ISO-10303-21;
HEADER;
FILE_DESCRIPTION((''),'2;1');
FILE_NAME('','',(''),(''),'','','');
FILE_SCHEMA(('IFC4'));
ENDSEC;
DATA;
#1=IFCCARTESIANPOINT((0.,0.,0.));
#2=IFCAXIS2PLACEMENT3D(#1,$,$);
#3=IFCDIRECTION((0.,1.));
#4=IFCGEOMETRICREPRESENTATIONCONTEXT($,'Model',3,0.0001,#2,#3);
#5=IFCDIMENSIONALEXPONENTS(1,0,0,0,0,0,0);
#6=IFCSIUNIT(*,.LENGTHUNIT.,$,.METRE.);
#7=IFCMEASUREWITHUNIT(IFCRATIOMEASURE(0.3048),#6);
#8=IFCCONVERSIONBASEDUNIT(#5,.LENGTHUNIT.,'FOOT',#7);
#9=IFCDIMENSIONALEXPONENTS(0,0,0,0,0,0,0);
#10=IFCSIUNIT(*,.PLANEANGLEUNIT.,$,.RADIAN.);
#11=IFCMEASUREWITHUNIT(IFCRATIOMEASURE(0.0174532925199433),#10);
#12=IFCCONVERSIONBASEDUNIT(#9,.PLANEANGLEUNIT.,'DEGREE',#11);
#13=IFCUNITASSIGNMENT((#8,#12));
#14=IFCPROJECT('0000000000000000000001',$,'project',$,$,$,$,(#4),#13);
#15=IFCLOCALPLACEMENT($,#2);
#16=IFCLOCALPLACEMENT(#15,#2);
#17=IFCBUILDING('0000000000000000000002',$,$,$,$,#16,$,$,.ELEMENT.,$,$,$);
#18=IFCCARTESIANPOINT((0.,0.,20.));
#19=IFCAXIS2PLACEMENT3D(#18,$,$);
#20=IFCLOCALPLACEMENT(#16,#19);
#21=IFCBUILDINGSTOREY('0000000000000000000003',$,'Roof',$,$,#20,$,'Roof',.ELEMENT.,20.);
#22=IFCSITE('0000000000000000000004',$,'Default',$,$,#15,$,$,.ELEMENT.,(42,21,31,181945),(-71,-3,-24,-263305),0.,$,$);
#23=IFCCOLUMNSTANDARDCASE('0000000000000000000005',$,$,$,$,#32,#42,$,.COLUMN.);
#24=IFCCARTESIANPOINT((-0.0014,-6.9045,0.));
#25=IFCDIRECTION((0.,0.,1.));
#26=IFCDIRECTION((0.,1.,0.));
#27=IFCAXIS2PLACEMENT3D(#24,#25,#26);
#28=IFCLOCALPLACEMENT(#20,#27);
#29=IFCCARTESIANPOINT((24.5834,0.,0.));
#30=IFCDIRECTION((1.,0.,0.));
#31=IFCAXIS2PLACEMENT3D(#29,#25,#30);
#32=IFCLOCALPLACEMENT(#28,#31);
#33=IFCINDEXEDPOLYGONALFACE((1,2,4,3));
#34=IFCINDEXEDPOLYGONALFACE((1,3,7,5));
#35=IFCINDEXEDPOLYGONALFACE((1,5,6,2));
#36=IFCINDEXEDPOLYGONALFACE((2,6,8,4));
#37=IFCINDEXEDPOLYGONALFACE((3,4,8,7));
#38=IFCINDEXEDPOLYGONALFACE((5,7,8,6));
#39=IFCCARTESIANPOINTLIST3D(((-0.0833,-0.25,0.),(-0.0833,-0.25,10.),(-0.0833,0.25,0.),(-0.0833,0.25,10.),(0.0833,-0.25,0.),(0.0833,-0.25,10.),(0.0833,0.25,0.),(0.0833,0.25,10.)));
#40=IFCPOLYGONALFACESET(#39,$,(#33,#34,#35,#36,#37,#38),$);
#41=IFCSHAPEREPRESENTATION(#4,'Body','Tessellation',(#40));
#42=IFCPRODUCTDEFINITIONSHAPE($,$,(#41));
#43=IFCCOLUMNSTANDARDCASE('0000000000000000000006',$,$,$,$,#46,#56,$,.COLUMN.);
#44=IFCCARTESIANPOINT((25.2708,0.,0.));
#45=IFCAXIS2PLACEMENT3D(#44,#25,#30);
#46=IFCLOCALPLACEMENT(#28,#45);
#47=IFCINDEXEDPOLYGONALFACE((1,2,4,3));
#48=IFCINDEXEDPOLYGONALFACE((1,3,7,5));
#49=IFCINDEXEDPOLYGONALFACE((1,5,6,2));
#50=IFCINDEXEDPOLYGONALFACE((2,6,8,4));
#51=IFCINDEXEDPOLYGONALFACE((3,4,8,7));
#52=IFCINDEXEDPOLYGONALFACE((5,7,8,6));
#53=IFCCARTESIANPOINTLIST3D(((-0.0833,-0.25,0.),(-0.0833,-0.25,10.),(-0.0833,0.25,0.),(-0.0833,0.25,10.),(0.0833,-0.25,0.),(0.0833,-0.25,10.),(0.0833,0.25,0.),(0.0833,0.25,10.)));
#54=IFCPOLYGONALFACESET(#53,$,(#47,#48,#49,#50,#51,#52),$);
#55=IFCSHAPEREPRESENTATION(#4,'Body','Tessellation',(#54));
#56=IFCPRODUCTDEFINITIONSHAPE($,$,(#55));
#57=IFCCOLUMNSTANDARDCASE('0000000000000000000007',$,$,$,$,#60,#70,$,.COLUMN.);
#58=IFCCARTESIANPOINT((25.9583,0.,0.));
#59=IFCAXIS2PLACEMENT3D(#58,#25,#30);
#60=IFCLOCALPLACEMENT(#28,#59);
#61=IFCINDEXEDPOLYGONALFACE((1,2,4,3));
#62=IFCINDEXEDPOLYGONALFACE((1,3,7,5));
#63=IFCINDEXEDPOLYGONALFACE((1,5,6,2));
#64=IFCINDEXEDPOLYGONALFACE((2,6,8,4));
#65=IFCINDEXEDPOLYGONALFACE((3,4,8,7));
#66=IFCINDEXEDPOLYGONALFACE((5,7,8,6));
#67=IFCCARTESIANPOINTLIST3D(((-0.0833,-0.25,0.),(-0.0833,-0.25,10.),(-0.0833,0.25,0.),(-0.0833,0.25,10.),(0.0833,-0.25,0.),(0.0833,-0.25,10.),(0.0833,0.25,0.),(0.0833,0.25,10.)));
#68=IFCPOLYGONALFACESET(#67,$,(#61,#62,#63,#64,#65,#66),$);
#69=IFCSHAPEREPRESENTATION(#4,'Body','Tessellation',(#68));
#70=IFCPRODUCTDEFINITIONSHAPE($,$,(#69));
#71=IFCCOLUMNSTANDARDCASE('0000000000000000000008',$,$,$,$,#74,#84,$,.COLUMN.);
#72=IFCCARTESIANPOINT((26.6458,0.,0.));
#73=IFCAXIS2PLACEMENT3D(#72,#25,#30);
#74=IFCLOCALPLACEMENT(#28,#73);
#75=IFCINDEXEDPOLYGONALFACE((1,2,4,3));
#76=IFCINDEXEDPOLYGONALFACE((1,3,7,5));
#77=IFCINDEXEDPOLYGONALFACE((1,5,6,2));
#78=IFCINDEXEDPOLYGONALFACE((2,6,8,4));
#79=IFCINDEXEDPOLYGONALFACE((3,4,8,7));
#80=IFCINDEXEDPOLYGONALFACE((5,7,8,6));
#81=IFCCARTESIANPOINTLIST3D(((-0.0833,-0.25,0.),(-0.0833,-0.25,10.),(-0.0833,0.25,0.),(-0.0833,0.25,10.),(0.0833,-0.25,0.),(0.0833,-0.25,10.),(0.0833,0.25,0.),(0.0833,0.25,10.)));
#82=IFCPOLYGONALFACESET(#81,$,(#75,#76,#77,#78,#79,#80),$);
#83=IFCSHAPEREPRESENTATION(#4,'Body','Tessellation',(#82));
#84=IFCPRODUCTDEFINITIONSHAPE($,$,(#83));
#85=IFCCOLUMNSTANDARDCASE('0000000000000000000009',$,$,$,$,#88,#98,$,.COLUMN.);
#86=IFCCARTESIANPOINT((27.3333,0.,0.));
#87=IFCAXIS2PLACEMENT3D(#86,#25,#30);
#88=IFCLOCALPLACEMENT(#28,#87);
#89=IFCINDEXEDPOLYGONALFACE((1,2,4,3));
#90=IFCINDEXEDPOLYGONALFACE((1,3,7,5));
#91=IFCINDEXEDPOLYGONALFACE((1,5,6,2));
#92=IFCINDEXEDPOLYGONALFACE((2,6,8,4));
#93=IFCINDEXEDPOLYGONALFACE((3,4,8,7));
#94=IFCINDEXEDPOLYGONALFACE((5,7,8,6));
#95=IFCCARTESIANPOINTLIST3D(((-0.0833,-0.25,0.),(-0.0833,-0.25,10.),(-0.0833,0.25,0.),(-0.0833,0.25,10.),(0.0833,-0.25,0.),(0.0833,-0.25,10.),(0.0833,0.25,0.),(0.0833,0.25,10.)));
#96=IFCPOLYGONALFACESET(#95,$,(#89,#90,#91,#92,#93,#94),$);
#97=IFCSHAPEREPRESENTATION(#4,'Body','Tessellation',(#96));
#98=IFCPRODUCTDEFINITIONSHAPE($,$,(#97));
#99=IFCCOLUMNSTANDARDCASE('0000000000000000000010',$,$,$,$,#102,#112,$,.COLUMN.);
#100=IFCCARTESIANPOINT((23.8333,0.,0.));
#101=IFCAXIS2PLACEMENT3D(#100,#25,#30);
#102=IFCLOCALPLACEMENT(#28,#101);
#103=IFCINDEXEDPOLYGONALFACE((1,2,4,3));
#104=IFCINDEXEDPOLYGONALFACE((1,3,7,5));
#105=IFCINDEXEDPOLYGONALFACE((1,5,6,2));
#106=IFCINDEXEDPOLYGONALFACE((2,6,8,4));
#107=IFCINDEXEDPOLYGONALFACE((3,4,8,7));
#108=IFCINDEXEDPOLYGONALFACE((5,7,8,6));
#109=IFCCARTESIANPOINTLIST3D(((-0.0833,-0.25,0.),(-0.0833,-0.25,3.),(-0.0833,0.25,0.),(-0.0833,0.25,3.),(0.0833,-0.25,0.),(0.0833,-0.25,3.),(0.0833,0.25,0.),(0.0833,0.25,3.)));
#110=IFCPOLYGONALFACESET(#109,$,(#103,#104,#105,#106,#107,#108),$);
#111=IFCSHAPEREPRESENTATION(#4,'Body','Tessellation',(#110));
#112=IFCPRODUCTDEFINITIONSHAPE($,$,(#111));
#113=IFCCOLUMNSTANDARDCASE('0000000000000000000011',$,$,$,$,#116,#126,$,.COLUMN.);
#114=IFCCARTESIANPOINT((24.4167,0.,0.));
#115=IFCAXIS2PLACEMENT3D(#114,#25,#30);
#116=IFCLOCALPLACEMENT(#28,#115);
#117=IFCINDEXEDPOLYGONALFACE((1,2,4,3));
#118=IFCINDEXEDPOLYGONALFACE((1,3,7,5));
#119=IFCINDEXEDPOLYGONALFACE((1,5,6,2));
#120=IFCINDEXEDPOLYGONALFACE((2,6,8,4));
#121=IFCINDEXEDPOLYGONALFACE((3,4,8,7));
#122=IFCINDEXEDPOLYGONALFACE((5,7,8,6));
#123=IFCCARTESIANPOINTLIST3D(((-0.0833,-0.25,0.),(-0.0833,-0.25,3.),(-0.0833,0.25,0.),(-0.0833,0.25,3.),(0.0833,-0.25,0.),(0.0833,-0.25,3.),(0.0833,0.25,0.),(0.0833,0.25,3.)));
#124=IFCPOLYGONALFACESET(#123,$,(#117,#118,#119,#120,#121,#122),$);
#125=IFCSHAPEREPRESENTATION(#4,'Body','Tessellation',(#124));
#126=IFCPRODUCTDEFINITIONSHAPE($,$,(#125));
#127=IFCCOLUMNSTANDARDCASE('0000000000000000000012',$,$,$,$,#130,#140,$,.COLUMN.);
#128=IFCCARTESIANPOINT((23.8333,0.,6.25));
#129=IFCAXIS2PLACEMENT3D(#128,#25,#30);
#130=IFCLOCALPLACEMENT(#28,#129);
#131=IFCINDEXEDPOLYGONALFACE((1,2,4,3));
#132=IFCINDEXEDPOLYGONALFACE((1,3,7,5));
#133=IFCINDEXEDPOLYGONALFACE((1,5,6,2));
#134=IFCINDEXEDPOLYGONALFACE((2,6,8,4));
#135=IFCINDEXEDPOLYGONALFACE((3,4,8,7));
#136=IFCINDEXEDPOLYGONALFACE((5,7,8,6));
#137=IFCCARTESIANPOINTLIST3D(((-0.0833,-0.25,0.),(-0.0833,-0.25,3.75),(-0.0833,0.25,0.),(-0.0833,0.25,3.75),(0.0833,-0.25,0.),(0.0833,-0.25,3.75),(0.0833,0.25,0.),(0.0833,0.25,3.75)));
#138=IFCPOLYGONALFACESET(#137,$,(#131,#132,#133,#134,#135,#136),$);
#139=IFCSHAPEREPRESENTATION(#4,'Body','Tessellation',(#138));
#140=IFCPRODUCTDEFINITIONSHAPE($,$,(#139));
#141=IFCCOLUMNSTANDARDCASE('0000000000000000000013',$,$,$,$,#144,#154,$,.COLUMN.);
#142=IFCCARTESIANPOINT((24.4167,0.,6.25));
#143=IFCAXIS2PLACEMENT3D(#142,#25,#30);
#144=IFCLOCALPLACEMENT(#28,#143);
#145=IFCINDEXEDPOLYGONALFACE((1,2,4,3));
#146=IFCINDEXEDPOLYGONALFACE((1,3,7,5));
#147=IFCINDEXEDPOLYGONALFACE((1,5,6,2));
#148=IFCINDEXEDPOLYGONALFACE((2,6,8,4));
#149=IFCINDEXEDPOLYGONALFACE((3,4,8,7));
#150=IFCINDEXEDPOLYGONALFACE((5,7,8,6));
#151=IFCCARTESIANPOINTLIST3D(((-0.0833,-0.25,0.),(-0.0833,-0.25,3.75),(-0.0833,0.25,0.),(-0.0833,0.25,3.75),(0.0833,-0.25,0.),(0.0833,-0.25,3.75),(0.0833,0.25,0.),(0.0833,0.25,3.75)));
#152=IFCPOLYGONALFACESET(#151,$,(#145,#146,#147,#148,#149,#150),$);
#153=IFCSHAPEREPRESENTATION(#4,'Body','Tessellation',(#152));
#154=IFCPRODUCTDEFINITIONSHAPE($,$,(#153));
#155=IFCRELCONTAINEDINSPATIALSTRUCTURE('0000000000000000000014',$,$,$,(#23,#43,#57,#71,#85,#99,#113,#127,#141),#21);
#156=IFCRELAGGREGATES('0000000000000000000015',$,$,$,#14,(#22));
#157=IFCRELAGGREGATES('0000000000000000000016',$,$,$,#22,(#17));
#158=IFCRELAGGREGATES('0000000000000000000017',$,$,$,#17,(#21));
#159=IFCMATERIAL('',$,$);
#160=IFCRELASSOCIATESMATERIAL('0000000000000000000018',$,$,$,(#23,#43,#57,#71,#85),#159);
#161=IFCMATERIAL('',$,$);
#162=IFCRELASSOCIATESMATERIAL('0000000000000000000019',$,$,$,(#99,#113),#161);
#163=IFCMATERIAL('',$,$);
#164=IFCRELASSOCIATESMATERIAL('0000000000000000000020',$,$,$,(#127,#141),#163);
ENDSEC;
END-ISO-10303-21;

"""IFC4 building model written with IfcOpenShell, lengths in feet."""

from ifc_helpers import new_model, entity, si_unit, converted_unit, direction, frame, origin, place, context, project, spatial, rectangle, extrude, material, element, save


model = new_model("IFC4")

# Units and contexts
model_context = context("Model", 3, precision=0.0001, world=origin(), true_north=direction((0.0, 1.0)))
ifc_project = project(units=[converted_unit("LENGTHUNIT", "FOOT", entity("IfcRatioMeasure", 0.3048), si_unit("LENGTHUNIT", "METRE"), dimensions=[1, 0, 0, 0, 0, 0, 0]), converted_unit("PLANEANGLEUNIT", "DEGREE", entity("IfcRatioMeasure", 0.0174532925199433), si_unit("PLANEANGLEUNIT", "RADIAN"), dimensions=[0, 0, 0, 0, 0, 0, 0])], contexts=[model_context])

# Site, building, storey
site_placement = place(None, origin())
site = spatial("IfcSite", under=ifc_project, at=site_placement, Name="Default", CompositionType="ELEMENT", RefLatitude=(42, 21, 31, 181945), RefLongitude=(-71, -3, -24, -263305), RefElevation=0.0)
building_placement = place(site_placement, origin())
building = spatial("IfcBuilding", under=site, at=building_placement, CompositionType="ELEMENT")
storey_placement = place(building_placement, frame((0.0, 0.0, 20.0)))
storey = spatial("IfcBuildingStorey", under=building, at=storey_placement, Name="Roof", LongName="Roof", CompositionType="ELEMENT", Elevation=20.0)

# Columns
ifc_material_1 = material(Name="")
placement = place(storey_placement, frame((-0.0014, -6.9045, 0.0), z_axis=(0.0, 0.0, 1.0), x_axis=(0.0, 1.0, 0.0)))
for number, where, z_axis, x_axis in (
    (1, (24.5834, 0.0, 0.0), (0.0, 0.0, 1.0), (1.0, 0.0, 0.0)),
    (2, (25.2708, 0.0, 0.0), (0.0, 0.0, 1.0), (1.0, 0.0, 0.0)),
    (3, (25.9583, 0.0, 0.0), (0.0, 0.0, 1.0), (1.0, 0.0, 0.0)),
    (4, (26.6458, 0.0, 0.0), (0.0, 0.0, 1.0), (1.0, 0.0, 0.0)),
    (5, (27.3333, 0.0, 0.0), (0.0, 0.0, 1.0), (1.0, 0.0, 0.0)),
):
    element("IfcColumnStandardCase", number, at=place(placement, frame(where, z_axis=z_axis, x_axis=x_axis)), inside=storey, material=ifc_material_1, PredefinedType="COLUMN", context=model_context, shape_type="SweptSolid", body=[
        extrude(rectangle(XDim=0.1667, YDim=0.5), origin(), (0.0, 0.0, 1.0), 10.0),
    ])
ifc_material_2 = material(Name="")
for number, where, z_axis, x_axis in (
    (6, (23.8333, 0.0, 0.0), (0.0, 0.0, 1.0), (1.0, 0.0, 0.0)),
    (7, (24.4167, 0.0, 0.0), (0.0, 0.0, 1.0), (1.0, 0.0, 0.0)),
):
    element("IfcColumnStandardCase", number, at=place(placement, frame(where, z_axis=z_axis, x_axis=x_axis)), inside=storey, material=ifc_material_2, PredefinedType="COLUMN", context=model_context, shape_type="SweptSolid", body=[
        extrude(rectangle(XDim=0.1667, YDim=0.5), origin(), (0.0, 0.0, 1.0), 3.0),
    ])
ifc_material_3 = material(Name="")
for number, where, z_axis, x_axis in (
    (8, (23.8333, 0.0, 6.25), (0.0, 0.0, 1.0), (1.0, 0.0, 0.0)),
    (9, (24.4167, 0.0, 6.25), (0.0, 0.0, 1.0), (1.0, 0.0, 0.0)),
):
    element("IfcColumnStandardCase", number, at=place(placement, frame(where, z_axis=z_axis, x_axis=x_axis)), inside=storey, material=ifc_material_3, PredefinedType="COLUMN", context=model_context, shape_type="SweptSolid", body=[
        extrude(rectangle(XDim=0.1667, YDim=0.5), origin(), (0.0, 0.0, 1.0), 3.75),
    ])

save(model, "model.ifc")
